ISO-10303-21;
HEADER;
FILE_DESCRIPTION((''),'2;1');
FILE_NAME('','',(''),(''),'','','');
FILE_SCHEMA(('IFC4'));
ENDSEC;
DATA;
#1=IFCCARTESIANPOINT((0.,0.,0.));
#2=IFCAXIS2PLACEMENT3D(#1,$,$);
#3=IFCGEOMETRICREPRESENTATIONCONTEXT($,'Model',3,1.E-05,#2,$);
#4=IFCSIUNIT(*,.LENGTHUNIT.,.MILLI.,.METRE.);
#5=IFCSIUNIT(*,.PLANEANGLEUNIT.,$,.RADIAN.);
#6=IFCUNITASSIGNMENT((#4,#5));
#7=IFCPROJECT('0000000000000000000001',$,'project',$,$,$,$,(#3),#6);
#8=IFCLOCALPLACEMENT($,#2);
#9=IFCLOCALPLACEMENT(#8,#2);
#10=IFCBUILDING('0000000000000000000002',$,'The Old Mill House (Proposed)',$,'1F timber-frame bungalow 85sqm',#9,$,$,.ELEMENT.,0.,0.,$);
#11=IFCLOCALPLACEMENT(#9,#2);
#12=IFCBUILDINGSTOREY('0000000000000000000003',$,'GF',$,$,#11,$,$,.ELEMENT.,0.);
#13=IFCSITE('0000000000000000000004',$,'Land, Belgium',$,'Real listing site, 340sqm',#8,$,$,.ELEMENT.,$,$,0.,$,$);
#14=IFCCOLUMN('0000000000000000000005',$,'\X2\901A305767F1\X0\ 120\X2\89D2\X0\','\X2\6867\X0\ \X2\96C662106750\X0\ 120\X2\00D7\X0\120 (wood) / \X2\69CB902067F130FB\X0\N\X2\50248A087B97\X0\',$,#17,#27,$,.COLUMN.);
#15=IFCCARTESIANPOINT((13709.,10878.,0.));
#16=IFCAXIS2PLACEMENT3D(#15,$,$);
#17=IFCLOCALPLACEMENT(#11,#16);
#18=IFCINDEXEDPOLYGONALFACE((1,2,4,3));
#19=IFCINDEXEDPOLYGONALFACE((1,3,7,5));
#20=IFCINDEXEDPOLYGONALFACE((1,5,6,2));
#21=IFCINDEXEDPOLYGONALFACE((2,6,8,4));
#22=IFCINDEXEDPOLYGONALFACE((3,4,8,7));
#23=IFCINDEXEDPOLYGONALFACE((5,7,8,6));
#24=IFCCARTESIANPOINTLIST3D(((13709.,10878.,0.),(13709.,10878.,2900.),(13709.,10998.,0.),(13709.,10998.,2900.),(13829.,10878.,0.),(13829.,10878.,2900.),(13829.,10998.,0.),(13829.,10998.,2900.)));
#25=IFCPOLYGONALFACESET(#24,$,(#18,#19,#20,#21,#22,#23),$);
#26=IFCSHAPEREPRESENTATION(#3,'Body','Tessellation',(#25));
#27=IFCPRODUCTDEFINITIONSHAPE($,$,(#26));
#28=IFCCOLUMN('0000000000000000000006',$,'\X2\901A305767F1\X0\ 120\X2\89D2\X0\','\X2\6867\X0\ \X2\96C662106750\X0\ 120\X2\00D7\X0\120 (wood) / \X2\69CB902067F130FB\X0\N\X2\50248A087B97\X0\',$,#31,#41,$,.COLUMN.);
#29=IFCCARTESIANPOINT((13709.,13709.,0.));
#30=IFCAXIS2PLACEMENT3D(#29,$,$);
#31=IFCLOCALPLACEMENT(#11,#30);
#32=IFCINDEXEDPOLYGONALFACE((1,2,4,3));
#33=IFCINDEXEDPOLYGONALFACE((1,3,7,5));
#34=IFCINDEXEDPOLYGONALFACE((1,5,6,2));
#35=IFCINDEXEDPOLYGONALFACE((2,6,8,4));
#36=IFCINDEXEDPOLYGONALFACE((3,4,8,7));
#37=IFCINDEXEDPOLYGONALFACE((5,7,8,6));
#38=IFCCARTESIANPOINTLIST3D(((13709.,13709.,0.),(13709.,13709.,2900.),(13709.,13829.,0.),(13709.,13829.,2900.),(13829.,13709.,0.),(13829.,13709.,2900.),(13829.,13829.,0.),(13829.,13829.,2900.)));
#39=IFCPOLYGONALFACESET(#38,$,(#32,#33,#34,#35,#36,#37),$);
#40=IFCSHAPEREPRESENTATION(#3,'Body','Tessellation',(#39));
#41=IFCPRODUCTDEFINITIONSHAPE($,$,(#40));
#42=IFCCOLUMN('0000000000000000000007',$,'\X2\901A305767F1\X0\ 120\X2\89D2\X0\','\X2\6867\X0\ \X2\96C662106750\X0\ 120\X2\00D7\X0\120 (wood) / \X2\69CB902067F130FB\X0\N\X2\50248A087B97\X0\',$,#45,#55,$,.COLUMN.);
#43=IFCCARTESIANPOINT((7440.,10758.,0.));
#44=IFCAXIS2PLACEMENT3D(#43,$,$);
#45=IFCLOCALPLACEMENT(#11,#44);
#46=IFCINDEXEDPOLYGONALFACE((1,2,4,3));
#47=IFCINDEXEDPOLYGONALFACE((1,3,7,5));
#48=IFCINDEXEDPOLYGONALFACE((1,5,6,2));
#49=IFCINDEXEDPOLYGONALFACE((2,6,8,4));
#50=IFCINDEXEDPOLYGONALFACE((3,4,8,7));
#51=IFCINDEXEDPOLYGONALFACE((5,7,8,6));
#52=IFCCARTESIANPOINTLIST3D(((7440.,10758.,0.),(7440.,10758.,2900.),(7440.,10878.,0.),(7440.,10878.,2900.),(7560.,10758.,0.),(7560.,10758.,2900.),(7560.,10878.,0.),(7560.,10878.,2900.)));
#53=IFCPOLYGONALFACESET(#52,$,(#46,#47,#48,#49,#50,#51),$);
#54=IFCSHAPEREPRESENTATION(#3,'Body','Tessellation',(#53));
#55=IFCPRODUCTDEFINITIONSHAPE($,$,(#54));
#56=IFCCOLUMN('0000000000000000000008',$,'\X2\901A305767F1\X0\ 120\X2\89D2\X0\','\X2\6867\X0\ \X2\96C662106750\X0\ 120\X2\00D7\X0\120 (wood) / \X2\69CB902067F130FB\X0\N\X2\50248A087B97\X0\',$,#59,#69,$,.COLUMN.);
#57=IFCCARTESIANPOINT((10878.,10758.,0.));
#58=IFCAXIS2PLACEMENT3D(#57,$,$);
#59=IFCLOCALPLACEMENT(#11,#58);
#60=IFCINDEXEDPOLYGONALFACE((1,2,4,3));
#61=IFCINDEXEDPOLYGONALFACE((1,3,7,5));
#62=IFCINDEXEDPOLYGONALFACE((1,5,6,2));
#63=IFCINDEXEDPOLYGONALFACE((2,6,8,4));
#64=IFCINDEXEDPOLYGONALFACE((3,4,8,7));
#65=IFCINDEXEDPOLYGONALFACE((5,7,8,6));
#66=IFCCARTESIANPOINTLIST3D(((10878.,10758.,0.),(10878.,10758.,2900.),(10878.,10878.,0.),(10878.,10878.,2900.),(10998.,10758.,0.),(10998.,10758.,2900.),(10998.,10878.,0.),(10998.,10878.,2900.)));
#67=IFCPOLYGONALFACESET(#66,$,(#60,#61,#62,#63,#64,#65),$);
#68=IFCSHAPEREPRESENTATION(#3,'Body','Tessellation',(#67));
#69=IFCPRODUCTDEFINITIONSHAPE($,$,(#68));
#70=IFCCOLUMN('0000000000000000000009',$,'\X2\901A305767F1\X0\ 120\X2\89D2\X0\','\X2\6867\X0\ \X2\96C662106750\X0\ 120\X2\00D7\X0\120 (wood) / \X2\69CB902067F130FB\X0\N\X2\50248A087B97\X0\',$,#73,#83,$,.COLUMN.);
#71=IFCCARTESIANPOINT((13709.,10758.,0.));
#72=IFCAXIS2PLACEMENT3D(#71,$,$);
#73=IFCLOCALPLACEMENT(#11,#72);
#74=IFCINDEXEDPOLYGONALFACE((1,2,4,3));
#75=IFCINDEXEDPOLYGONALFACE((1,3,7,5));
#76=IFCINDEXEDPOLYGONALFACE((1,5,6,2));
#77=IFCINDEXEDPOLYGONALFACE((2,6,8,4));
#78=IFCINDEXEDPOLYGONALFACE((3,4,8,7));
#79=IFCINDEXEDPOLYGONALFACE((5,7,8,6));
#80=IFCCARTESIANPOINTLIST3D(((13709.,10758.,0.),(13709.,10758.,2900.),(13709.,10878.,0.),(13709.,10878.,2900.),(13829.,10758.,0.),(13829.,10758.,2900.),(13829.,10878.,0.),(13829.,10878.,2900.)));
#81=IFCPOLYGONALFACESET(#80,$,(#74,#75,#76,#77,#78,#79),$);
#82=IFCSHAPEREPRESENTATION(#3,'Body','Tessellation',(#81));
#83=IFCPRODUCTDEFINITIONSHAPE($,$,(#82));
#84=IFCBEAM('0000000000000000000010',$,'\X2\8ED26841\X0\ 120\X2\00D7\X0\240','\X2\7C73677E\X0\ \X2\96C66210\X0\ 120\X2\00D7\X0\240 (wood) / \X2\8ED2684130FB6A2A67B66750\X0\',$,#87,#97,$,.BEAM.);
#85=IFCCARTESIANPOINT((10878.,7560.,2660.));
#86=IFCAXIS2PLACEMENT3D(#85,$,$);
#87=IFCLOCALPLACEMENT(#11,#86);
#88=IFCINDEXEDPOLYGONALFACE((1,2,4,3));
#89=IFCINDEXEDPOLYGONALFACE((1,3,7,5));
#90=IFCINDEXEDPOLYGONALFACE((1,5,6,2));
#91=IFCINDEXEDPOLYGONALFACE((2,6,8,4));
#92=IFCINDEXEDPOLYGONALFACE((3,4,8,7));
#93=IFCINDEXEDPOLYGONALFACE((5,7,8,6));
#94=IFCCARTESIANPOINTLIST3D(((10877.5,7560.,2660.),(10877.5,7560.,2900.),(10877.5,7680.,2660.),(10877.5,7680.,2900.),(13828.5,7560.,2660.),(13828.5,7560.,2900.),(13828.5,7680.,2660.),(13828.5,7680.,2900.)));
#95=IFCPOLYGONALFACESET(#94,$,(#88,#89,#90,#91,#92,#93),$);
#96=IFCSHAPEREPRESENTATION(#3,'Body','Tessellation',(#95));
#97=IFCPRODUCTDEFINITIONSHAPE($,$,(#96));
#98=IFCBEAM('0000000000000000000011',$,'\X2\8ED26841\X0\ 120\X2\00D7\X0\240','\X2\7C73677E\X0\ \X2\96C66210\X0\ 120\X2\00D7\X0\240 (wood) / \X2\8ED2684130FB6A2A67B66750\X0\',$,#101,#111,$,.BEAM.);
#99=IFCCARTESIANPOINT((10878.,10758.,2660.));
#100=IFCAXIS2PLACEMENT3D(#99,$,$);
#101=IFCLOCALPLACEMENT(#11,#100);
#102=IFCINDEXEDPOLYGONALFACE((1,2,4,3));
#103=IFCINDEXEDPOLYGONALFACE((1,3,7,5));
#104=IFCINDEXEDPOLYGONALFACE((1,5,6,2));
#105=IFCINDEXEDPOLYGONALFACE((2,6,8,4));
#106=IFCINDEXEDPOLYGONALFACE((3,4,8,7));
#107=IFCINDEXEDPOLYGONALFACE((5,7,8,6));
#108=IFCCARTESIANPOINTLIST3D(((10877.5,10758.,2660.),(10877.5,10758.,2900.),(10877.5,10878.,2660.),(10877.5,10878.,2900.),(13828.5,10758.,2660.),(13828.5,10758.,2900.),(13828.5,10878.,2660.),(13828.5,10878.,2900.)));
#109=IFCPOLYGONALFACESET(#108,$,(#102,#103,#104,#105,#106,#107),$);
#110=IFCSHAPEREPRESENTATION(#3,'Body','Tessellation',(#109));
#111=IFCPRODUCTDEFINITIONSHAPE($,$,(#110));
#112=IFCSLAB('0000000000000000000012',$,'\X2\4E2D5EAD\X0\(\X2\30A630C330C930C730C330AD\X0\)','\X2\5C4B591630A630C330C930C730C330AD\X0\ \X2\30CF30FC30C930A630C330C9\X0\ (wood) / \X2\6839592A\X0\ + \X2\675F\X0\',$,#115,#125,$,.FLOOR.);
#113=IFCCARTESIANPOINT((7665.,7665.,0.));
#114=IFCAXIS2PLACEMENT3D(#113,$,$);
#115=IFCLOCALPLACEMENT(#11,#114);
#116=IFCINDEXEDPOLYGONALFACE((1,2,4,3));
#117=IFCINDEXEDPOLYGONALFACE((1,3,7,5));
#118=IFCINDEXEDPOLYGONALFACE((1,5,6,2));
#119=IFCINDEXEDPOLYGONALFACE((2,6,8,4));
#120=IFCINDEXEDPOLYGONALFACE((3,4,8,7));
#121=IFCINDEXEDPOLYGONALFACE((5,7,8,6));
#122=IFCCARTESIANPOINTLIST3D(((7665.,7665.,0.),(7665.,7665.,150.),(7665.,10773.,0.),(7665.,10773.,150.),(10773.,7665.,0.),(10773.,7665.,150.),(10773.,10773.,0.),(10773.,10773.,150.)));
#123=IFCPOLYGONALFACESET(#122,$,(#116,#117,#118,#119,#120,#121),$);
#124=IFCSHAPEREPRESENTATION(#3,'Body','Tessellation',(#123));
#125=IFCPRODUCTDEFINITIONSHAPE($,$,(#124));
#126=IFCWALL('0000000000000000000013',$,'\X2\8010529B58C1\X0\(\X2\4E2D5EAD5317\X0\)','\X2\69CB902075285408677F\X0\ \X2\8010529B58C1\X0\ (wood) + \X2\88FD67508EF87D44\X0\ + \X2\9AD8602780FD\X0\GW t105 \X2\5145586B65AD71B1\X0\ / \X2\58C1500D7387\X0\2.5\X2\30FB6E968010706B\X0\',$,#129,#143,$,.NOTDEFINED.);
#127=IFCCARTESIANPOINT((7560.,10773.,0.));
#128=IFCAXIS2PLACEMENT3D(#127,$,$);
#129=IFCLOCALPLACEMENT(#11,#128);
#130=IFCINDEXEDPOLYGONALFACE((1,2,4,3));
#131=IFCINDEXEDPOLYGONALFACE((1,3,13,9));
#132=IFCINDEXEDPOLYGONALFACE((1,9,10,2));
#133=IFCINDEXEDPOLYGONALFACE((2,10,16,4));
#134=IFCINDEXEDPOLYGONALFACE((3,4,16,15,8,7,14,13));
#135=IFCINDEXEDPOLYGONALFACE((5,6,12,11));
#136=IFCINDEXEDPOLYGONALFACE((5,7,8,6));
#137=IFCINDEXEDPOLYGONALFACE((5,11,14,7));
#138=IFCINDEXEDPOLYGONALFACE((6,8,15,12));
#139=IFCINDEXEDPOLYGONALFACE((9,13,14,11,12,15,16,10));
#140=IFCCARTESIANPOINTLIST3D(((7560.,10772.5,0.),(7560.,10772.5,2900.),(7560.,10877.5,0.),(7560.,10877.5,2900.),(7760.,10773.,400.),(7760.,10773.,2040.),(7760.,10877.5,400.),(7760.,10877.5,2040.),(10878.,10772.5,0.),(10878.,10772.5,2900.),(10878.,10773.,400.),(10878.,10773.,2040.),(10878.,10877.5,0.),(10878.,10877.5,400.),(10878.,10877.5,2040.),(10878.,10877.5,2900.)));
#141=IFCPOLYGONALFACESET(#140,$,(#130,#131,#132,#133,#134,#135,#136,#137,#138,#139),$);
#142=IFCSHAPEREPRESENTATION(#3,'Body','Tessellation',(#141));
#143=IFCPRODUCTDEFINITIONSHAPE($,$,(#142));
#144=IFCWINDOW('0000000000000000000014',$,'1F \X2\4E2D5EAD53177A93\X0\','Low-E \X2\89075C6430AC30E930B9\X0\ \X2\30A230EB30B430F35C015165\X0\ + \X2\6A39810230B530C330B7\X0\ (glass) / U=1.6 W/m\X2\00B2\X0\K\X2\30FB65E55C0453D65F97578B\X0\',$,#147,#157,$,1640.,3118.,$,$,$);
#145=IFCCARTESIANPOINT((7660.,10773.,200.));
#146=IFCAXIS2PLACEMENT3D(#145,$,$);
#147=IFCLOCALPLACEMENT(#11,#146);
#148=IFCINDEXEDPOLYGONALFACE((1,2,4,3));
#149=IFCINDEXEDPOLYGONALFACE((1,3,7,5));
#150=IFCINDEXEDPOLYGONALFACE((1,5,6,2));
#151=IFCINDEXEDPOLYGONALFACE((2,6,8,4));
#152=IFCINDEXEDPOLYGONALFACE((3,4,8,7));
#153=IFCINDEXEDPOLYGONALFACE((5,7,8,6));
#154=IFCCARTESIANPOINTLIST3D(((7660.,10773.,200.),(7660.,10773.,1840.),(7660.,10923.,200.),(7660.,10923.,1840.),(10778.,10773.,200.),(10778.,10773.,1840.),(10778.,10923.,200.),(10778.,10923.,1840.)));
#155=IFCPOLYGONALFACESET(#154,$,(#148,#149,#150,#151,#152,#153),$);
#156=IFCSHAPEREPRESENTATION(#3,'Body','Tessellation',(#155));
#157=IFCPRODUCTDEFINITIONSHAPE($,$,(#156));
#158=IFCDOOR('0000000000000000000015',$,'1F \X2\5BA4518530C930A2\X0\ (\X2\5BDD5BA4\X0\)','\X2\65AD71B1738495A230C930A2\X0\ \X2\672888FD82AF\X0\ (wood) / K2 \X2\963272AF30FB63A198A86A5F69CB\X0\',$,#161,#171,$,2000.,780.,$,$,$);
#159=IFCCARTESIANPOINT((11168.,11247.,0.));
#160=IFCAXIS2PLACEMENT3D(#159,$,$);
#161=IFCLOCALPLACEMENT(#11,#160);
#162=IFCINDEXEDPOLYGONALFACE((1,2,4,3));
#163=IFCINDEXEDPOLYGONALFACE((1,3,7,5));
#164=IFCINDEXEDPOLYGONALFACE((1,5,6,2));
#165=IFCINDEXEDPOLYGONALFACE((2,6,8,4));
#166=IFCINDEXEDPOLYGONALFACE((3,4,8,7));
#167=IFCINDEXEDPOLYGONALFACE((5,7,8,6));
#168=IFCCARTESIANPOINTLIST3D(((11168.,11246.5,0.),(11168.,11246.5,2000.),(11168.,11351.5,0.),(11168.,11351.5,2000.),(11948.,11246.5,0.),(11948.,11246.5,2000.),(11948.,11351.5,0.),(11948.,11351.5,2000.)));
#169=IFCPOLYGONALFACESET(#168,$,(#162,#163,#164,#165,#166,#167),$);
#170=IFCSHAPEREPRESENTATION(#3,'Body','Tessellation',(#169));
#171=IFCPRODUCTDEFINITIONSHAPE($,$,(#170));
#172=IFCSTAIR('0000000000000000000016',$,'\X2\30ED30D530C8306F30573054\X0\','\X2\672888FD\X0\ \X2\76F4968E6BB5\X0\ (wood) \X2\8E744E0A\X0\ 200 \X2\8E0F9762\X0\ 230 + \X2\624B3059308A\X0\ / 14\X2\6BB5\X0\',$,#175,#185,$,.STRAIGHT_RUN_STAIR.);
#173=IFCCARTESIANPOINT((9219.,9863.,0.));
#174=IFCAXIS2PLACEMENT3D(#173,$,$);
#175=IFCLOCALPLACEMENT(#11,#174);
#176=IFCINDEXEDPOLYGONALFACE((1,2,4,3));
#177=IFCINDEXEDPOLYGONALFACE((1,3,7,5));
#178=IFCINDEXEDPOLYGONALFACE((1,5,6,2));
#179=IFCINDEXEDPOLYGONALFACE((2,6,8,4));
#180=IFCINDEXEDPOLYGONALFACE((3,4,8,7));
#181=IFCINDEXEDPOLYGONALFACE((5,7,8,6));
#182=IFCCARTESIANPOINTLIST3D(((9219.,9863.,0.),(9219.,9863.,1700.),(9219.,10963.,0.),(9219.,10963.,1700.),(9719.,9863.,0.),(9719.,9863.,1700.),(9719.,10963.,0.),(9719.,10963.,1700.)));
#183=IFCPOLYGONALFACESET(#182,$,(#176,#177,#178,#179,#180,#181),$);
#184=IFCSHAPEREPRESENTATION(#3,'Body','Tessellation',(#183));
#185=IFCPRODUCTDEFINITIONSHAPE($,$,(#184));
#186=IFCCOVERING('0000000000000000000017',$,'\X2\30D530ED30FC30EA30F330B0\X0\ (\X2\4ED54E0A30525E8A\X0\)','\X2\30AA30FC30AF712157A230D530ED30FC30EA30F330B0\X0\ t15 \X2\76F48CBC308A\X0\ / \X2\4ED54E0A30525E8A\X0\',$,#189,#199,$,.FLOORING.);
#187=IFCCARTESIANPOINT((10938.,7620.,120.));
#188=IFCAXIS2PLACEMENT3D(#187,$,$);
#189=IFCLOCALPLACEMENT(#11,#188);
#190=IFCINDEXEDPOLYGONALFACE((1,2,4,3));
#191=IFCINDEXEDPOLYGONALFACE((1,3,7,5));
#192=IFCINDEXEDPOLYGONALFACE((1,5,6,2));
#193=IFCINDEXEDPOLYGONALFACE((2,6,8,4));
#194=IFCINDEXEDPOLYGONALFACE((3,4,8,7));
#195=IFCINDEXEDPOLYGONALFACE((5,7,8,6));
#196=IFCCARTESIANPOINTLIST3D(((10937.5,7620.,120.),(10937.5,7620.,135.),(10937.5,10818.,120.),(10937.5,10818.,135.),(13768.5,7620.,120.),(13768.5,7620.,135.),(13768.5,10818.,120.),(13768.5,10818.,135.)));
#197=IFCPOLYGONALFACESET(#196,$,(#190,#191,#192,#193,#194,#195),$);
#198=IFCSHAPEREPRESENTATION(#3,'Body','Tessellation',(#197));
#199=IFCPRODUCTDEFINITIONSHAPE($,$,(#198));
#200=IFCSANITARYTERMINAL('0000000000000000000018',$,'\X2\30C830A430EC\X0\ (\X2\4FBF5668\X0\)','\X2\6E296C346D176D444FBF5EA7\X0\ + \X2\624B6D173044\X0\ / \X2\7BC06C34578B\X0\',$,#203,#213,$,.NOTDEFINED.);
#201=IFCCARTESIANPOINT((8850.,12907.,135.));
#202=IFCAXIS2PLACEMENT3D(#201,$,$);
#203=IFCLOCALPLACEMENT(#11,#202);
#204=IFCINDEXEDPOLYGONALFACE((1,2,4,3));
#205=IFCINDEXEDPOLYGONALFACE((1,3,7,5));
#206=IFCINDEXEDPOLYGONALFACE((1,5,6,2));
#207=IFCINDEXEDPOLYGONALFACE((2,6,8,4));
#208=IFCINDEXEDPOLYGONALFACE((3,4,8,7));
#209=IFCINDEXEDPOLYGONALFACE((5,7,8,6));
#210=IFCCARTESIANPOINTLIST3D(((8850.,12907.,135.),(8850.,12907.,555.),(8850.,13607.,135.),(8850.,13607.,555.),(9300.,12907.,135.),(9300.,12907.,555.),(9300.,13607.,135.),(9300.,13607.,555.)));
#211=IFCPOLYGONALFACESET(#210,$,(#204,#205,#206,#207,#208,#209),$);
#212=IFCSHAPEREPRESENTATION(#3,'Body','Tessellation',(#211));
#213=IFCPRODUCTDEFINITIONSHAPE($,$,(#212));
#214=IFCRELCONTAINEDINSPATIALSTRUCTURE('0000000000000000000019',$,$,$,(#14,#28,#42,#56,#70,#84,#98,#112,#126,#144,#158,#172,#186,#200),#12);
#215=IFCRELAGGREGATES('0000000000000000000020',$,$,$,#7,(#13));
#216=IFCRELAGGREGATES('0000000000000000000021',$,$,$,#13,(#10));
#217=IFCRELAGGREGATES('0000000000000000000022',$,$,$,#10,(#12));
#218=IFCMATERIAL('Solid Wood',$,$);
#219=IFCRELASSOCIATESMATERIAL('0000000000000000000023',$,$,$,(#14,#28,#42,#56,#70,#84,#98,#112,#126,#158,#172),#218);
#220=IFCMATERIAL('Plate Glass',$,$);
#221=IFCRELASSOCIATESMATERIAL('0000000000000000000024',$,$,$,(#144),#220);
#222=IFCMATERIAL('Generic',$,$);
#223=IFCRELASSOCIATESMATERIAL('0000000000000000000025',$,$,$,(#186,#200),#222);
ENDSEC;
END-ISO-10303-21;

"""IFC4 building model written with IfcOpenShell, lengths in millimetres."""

from ifc_helpers import new_model, si_unit, frame, frame_2d, origin, place, context, project, spatial, rectangle, extrude, material, element, fill, save


model = new_model("IFC4")

# Units and contexts
model_context = context("Model", 3, precision=1e-05, world=origin())
ifc_project = project(units=[si_unit("LENGTHUNIT", "METRE", prefix="MILLI"), si_unit("PLANEANGLEUNIT", "RADIAN")], contexts=[model_context])

# Site, building, storey
site_placement = place(None, origin())
site = spatial("IfcSite", under=ifc_project, at=site_placement, Name="Land, Belgium", ObjectType="Real listing site, 340sqm", CompositionType="ELEMENT", RefElevation=0.0)
building_placement = place(site_placement, origin())
building = spatial("IfcBuilding", under=site, at=building_placement, Name="The Old Mill House (Proposed)", ObjectType="1F timber-frame bungalow 85sqm", CompositionType="ELEMENT", ElevationOfRefHeight=0.0, ElevationOfTerrain=0.0)
storey_placement = place(building_placement, origin())
storey = spatial("IfcBuildingStorey", under=building, at=storey_placement, Name="GF", CompositionType="ELEMENT", Elevation=0.0)

# Columns
ifc_material_1 = material(Name="Solid Wood")
column_1_placement = place(storey_placement, frame((13709.0, 10878.0, 0.0)))
element("IfcColumn", 1, at=column_1_placement, inside=storey, material=ifc_material_1, Name="通し柱 120角", Description="桧 集成材 120×120 (wood) / 構造柱・N値計算", PredefinedType="COLUMN", context=model_context, shape_type="SweptSolid", body=[
    extrude(rectangle(XDim=120.0, YDim=120.0, at=frame_2d((60.0, 60.0))), frame((13709.0, 10878.0, 0.0)), (0.0, 0.0, 1.0), 2900.0),
])
column_2_placement = place(storey_placement, frame((13709.0, 13709.0, 0.0)))
element("IfcColumn", 2, at=column_2_placement, inside=storey, material=ifc_material_1, Name="通し柱 120角", Description="桧 集成材 120×120 (wood) / 構造柱・N値計算", PredefinedType="COLUMN", context=model_context, shape_type="SweptSolid", body=[
    extrude(rectangle(XDim=120.0, YDim=120.0, at=frame_2d((60.0, 60.0))), frame((13709.0, 13709.0, 0.0)), (0.0, 0.0, 1.0), 2900.0),
])
column_3_placement = place(storey_placement, frame((7440.0, 10758.0, 0.0)))
element("IfcColumn", 3, at=column_3_placement, inside=storey, material=ifc_material_1, Name="通し柱 120角", Description="桧 集成材 120×120 (wood) / 構造柱・N値計算", PredefinedType="COLUMN", context=model_context, shape_type="SweptSolid", body=[
    extrude(rectangle(XDim=120.0, YDim=120.0, at=frame_2d((60.0, 60.0))), frame((7440.0, 10758.0, 0.0)), (0.0, 0.0, 1.0), 2900.0),
])
column_4_placement = place(storey_placement, frame((10878.0, 10758.0, 0.0)))
element("IfcColumn", 4, at=column_4_placement, inside=storey, material=ifc_material_1, Name="通し柱 120角", Description="桧 集成材 120×120 (wood) / 構造柱・N値計算", PredefinedType="COLUMN", context=model_context, shape_type="SweptSolid", body=[
    extrude(rectangle(XDim=120.0, YDim=120.0, at=frame_2d((60.0, 60.0))), frame((10878.0, 10758.0, 0.0)), (0.0, 0.0, 1.0), 2900.0),
])
column_5_placement = place(storey_placement, frame((13709.0, 10758.0, 0.0)))
element("IfcColumn", 5, at=column_5_placement, inside=storey, material=ifc_material_1, Name="通し柱 120角", Description="桧 集成材 120×120 (wood) / 構造柱・N値計算", PredefinedType="COLUMN", context=model_context, shape_type="SweptSolid", body=[
    extrude(rectangle(XDim=120.0, YDim=120.0, at=frame_2d((60.0, 60.0))), frame((13709.0, 10758.0, 0.0)), (0.0, 0.0, 1.0), 2900.0),
])

# Beams
beam_1_placement = place(storey_placement, frame((10878.0, 7560.0, 2660.0)))
element("IfcBeam", 6, at=beam_1_placement, inside=storey, material=ifc_material_1, Name="軒桁 120×240", Description="米松 集成 120×240 (wood) / 軒桁・横架材", PredefinedType="BEAM", context=model_context, shape_type="SweptSolid", body=[
    extrude(rectangle(XDim=2951.0, YDim=120.0, at=frame_2d((1475.0, 60.0))), frame((10878.0, 7560.0, 2660.0)), (0.0, 0.0, 1.0), 240.0),
])
beam_2_placement = place(storey_placement, frame((10878.0, 10758.0, 2660.0)))
element("IfcBeam", 7, at=beam_2_placement, inside=storey, material=ifc_material_1, Name="軒桁 120×240", Description="米松 集成 120×240 (wood) / 軒桁・横架材", PredefinedType="BEAM", context=model_context, shape_type="SweptSolid", body=[
    extrude(rectangle(XDim=2951.0, YDim=120.0, at=frame_2d((1475.0, 60.0))), frame((10878.0, 10758.0, 2660.0)), (0.0, 0.0, 1.0), 240.0),
])

# Slab
slab_placement = place(storey_placement, frame((7665.0, 7665.0, 0.0)))
element("IfcSlab", 8, at=slab_placement, inside=storey, material=ifc_material_1, Name="中庭(ウッドデッキ)", Description="屋外ウッドデッキ ハードウッド (wood) / 根太 + 束", PredefinedType="FLOOR", context=model_context, shape_type="SweptSolid", body=[
    extrude(rectangle(XDim=3108.0, YDim=3108.0, at=frame_2d((1554.0, 1554.0))), frame((7665.0, 7665.0, 0.0)), (0.0, 0.0, 1.0), 150.0),
])

# Wall, opening, window
wall_1_placement = place(storey_placement, frame((7560.0, 10773.0, 0.0)))
wall_1 = element("IfcWall", 9, at=wall_1_placement, inside=storey, material=ifc_material_1, Name="耐力壁(中庭北)", Description="構造用合板 耐力壁 (wood) + 製材軸組 + 高性能GW t105 充填断熱 / 壁倍率2.5・準耐火", PredefinedType="NOTDEFINED", context=model_context, shape_type="SweptSolid", body=[
    extrude(rectangle(XDim=3318.0, YDim=105.0, at=frame_2d((1659.0, 52.0))), frame((7560.0, 10773.0, 0.0)), (0.0, 0.0, 1.0), 2900.0),
])
opening_placement = place(storey_placement, frame((7660.0, 10773.0, 200.0)))
opening = element("IfcOpeningElement", 10, at=opening_placement, cuts=wall_1, PredefinedType="NOTDEFINED", context=model_context, shape_type="SweptSolid", body=[
    extrude(rectangle(XDim=3118.0, YDim=150.0, at=frame_2d((1559.0, 75.0))), frame((7660.0, 10773.0, 200.0)), (0.0, 0.0, 1.0), 1640.0),
])
ifc_material_2 = material(Name="Plate Glass")
window_placement = place(storey_placement, frame((7660.0, 10773.0, 200.0)))
window = element("IfcWindow", 11, at=window_placement, inside=storey, material=ifc_material_2, Name="1F 中庭北窓", Description="Low-E 複層ガラス アルゴン封入 + 樹脂サッシ (glass) / U=1.6 W/m²K・日射取得型", OverallHeight=1640.0, OverallWidth=3118.0, context=model_context, shape_type="SweptSolid", body=[
    extrude(rectangle(XDim=3118.0, YDim=150.0, at=frame_2d((1559.0, 75.0))), frame((7660.0, 10773.0, 200.0)), (0.0, 0.0, 1.0), 1640.0),
])
fill(opening, window)

# Door
door_placement = place(storey_placement, frame((11168.0, 11247.0, 0.0)))
element("IfcDoor", 12, at=door_placement, inside=storey, material=ifc_material_1, Name="1F 室内ドア (寝室)", Description="断熱玄関ドア 木製芯 (wood) / K2 防犯・採風機構", OverallHeight=2000.0, OverallWidth=780.0, context=model_context, shape_type="SweptSolid", body=[
    extrude(rectangle(XDim=780.0, YDim=105.0, at=frame_2d((390.0, 52.0))), frame((11168.0, 11247.0, 0.0)), (0.0, 0.0, 1.0), 2000.0),
])

# Stair
stair_placement = place(storey_placement, frame((9219.0, 9863.0, 0.0)))
element("IfcStair", 13, at=stair_placement, inside=storey, material=ifc_material_1, Name="ロフトはしご", Description="木製 直階段 (wood) 蹴上 200 踏面 230 + 手すり / 14段", PredefinedType="STRAIGHT_RUN_STAIR", context=model_context, shape_type="SweptSolid", body=[
    extrude(rectangle(XDim=500.0, YDim=1100.0, at=frame_2d((250.0, 550.0))), frame((9219.0, 9863.0, 0.0)), (0.0, 0.0, 1.0), 1700.0),
])

# Covering
ifc_material_3 = material(Name="Generic")
covering_placement = place(storey_placement, frame((10938.0, 7620.0, 120.0)))
element("IfcCovering", 14, at=covering_placement, inside=storey, material=ifc_material_3, Name="フローリング (仕上げ床)", Description="オーク無垢フローリング t15 直貼り / 仕上げ床", PredefinedType="FLOORING", context=model_context, shape_type="SweptSolid", body=[
    extrude(rectangle(XDim=2831.0, YDim=3198.0, at=frame_2d((1415.0, 1599.0))), frame((10938.0, 7620.0, 120.0)), (0.0, 0.0, 1.0), 15.0),
])

# Sanitary terminal
sanitary_terminal_placement = place(storey_placement, frame((8850.0, 12907.0, 135.0)))
element("IfcSanitaryTerminal", 15, at=sanitary_terminal_placement, inside=storey, material=ifc_material_3, Name="トイレ (便器)", Description="温水洗浄便座 + 手洗い / 節水型", PredefinedType="NOTDEFINED", context=model_context, shape_type="SweptSolid", body=[
    extrude(rectangle(XDim=450.0, YDim=700.0, at=frame_2d((225.0, 350.0))), frame((8850.0, 12907.0, 135.0)), (0.0, 0.0, 1.0), 420.0),
])

save(model, "model.ifc")
